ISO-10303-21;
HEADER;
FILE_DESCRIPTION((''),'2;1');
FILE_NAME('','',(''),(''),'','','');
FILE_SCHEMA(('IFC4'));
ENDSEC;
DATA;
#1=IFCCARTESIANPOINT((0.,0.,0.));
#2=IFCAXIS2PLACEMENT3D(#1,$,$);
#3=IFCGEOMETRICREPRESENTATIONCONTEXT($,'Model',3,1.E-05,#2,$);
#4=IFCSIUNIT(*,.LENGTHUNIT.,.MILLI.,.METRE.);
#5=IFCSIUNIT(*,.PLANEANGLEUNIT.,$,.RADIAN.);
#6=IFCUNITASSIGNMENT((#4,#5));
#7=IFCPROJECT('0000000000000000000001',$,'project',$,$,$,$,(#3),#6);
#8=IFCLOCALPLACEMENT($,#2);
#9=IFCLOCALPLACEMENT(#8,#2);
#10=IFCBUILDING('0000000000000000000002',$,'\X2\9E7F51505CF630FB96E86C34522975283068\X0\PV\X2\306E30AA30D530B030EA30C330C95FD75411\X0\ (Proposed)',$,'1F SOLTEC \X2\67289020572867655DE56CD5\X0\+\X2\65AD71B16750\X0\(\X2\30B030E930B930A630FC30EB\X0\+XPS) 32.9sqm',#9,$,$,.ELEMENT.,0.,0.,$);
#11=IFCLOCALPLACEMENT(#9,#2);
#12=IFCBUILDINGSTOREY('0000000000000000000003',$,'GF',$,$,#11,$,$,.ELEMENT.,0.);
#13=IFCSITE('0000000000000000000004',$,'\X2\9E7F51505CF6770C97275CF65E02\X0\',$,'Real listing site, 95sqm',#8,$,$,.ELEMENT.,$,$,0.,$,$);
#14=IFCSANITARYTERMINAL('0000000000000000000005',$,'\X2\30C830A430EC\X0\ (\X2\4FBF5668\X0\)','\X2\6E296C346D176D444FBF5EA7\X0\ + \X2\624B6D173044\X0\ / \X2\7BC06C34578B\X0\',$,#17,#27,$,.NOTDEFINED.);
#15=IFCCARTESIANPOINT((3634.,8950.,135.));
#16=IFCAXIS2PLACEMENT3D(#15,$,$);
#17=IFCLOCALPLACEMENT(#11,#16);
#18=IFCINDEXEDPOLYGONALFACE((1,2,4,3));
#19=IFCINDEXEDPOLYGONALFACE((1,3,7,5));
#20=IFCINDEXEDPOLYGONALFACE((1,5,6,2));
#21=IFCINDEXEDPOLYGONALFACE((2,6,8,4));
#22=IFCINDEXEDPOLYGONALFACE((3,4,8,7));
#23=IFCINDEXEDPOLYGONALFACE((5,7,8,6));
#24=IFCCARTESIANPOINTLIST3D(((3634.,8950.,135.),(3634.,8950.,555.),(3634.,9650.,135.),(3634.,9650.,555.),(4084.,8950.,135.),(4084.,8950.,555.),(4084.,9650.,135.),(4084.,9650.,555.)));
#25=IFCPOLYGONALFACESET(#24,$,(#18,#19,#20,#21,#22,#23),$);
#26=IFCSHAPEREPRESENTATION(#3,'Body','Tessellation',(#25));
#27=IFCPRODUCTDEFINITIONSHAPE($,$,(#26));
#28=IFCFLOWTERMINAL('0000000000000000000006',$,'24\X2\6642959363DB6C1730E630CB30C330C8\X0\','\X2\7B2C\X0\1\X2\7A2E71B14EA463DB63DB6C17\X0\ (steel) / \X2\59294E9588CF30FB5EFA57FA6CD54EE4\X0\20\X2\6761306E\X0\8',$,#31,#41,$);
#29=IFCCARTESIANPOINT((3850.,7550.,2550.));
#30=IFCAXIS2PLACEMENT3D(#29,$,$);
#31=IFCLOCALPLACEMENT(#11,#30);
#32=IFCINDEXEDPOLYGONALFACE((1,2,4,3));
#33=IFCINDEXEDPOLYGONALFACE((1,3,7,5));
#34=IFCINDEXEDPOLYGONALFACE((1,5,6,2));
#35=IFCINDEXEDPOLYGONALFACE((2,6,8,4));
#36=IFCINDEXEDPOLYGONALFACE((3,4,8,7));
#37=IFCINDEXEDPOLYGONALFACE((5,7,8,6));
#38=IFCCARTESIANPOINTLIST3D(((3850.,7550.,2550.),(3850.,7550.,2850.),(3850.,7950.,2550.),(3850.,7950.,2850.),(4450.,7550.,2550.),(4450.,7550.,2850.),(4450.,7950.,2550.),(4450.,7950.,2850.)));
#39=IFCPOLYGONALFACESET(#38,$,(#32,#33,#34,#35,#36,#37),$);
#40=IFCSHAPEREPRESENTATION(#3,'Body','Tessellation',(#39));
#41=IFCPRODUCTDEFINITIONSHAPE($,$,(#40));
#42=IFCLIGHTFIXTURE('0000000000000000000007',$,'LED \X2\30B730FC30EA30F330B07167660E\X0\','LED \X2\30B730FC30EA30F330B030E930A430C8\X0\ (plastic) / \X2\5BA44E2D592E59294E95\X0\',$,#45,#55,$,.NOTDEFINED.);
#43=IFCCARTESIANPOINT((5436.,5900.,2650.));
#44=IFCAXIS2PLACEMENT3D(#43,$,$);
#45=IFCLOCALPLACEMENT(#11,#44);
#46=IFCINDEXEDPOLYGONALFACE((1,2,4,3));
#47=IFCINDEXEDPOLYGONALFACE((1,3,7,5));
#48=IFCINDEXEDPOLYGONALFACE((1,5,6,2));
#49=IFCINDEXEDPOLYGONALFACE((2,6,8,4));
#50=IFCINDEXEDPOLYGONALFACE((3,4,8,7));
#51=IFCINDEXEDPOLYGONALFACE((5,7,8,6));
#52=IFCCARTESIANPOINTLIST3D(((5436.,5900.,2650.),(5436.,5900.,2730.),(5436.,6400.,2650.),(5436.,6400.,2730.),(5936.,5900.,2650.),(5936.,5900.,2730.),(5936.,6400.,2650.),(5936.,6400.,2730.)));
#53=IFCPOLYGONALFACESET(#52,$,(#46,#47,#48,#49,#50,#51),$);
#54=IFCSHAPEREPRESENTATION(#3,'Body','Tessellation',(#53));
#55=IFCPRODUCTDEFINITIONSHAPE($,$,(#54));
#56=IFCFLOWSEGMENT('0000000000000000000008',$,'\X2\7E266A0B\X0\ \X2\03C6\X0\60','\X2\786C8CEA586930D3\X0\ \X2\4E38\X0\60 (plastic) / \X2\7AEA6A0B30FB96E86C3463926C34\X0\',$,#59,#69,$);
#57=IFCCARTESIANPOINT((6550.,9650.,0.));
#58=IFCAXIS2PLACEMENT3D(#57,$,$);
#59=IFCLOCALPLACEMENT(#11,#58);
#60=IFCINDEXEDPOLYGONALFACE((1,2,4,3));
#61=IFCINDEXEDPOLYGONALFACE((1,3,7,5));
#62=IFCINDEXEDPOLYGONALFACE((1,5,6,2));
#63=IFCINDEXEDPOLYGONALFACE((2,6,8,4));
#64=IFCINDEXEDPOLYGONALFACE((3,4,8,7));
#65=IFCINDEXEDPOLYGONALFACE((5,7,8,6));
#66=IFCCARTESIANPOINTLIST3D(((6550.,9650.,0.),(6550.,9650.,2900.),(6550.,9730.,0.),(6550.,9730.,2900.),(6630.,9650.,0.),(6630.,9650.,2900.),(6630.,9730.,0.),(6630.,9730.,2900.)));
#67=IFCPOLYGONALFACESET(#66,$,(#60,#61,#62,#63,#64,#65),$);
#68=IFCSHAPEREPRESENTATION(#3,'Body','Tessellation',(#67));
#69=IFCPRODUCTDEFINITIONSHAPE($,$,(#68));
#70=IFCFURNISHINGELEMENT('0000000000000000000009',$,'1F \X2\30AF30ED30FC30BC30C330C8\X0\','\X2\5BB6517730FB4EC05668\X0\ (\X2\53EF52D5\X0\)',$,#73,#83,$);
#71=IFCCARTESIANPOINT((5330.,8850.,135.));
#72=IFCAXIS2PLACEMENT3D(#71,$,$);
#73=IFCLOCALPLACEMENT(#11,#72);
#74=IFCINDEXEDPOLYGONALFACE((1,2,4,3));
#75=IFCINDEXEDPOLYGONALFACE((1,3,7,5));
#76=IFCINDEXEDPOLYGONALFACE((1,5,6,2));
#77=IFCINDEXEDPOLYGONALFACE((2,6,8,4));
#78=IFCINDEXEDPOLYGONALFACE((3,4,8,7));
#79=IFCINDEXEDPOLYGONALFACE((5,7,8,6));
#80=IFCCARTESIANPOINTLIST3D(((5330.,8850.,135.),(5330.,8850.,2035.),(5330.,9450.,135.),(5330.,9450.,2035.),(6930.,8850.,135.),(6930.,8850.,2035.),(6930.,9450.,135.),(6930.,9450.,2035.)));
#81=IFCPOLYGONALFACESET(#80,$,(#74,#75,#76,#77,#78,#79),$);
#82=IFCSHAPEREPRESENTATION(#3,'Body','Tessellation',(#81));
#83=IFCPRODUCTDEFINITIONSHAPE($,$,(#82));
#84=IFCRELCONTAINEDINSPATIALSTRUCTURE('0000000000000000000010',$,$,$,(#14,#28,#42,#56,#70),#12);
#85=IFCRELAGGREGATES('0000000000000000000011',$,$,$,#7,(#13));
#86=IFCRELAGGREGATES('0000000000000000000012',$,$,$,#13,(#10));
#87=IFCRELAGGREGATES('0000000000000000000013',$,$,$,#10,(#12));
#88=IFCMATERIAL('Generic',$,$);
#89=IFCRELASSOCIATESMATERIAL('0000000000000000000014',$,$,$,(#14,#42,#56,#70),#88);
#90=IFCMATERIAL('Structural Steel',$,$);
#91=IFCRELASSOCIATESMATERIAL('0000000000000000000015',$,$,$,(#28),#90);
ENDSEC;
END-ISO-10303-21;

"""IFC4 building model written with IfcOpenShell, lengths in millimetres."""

from ifc_helpers import new_model, si_unit, frame, frame_2d, origin, place, context, project, spatial, rectangle, extrude, material, element, save


model = new_model("IFC4")

# Units and contexts
model_context = context("Model", 3, precision=1e-05, world=origin())
ifc_project = project(units=[si_unit("LENGTHUNIT", "METRE", prefix="MILLI"), si_unit("PLANEANGLEUNIT", "RADIAN")], contexts=[model_context])

# Site, building, storey
site_placement = place(None, origin())
site = spatial("IfcSite", under=ifc_project, at=site_placement, Name="鹿児島県霧島市", ObjectType="Real listing site, 95sqm", CompositionType="ELEMENT", RefElevation=0.0)
building_placement = place(site_placement, origin())
building = spatial("IfcBuilding", under=site, at=building_placement, Name="鹿児島・雨水利用とPVのオフグリッド志向 (Proposed)", ObjectType="1F SOLTEC 木造在来工法+断熱材(グラスウール+XPS) 32.9sqm", CompositionType="ELEMENT", ElevationOfRefHeight=0.0, ElevationOfTerrain=0.0)
storey_placement = place(building_placement, origin())
storey = spatial("IfcBuildingStorey", under=building, at=storey_placement, Name="GF", CompositionType="ELEMENT", Elevation=0.0)

# Shared definitions
ifc_material_1 = material(Name="Generic")

# Sanitary terminal
sanitary_terminal_placement = place(storey_placement, frame((3634.0, 8950.0, 135.0)))
element("IfcSanitaryTerminal", 1, at=sanitary_terminal_placement, inside=storey, material=ifc_material_1, Name="トイレ (便器)", Description="温水洗浄便座 + 手洗い / 節水型", PredefinedType="NOTDEFINED", context=model_context, shape_type="SweptSolid", body=[
    extrude(rectangle(XDim=450.0, YDim=700.0, at=frame_2d((225.0, 350.0))), frame((3634.0, 8950.0, 135.0)), (0.0, 0.0, 1.0), 420.0),
])

# Flow terminal
ifc_material_2 = material(Name="Structural Steel")
flow_terminal_placement = place(storey_placement, frame((3850.0, 7550.0, 2550.0)))
element("IfcFlowTerminal", 2, at=flow_terminal_placement, inside=storey, material=ifc_material_2, Name="24時間換気ユニット", Description="第1種熱交換換気 (steel) / 天井裏・建基法令20条の8", context=model_context, shape_type="SweptSolid", body=[
    extrude(rectangle(XDim=600.0, YDim=400.0, at=frame_2d((300.0, 200.0))), frame((3850.0, 7550.0, 2550.0)), (0.0, 0.0, 1.0), 300.0),
])

# Light fixture
light_fixture_placement = place(storey_placement, frame((5436.0, 5900.0, 2650.0)))
element("IfcLightFixture", 3, at=light_fixture_placement, inside=storey, material=ifc_material_1, Name="LED シーリング照明", Description="LED シーリングライト (plastic) / 室中央天井", PredefinedType="NOTDEFINED", context=model_context, shape_type="SweptSolid", body=[
    extrude(rectangle(XDim=500.0, YDim=500.0, at=frame_2d((250.0, 250.0))), frame((5436.0, 5900.0, 2650.0)), (0.0, 0.0, 1.0), 80.0),
])

# Flow segment
flow_segment_placement = place(storey_placement, frame((6550.0, 9650.0, 0.0)))
element("IfcFlowSegment", 4, at=flow_segment_placement, inside=storey, material=ifc_material_1, Name="縦樋 φ60", Description="硬質塩ビ 丸60 (plastic) / 竪樋・雨水排水", context=model_context, shape_type="SweptSolid", body=[
    extrude(rectangle(XDim=80.0, YDim=80.0, at=frame_2d((40.0, 40.0))), frame((6550.0, 9650.0, 0.0)), (0.0, 0.0, 1.0), 2900.0),
])

# Furnishing element
furnishing_placement = place(storey_placement, frame((5330.0, 8850.0, 135.0)))
element("IfcFurnishingElement", 5, at=furnishing_placement, inside=storey, material=ifc_material_1, Name="1F クローゼット", Description="家具・什器 (可動)", context=model_context, shape_type="SweptSolid", body=[
    extrude(rectangle(XDim=1600.0, YDim=600.0, at=frame_2d((800.0, 300.0))), frame((5330.0, 8850.0, 135.0)), (0.0, 0.0, 1.0), 1900.0),
])

save(model, "model.ifc")
